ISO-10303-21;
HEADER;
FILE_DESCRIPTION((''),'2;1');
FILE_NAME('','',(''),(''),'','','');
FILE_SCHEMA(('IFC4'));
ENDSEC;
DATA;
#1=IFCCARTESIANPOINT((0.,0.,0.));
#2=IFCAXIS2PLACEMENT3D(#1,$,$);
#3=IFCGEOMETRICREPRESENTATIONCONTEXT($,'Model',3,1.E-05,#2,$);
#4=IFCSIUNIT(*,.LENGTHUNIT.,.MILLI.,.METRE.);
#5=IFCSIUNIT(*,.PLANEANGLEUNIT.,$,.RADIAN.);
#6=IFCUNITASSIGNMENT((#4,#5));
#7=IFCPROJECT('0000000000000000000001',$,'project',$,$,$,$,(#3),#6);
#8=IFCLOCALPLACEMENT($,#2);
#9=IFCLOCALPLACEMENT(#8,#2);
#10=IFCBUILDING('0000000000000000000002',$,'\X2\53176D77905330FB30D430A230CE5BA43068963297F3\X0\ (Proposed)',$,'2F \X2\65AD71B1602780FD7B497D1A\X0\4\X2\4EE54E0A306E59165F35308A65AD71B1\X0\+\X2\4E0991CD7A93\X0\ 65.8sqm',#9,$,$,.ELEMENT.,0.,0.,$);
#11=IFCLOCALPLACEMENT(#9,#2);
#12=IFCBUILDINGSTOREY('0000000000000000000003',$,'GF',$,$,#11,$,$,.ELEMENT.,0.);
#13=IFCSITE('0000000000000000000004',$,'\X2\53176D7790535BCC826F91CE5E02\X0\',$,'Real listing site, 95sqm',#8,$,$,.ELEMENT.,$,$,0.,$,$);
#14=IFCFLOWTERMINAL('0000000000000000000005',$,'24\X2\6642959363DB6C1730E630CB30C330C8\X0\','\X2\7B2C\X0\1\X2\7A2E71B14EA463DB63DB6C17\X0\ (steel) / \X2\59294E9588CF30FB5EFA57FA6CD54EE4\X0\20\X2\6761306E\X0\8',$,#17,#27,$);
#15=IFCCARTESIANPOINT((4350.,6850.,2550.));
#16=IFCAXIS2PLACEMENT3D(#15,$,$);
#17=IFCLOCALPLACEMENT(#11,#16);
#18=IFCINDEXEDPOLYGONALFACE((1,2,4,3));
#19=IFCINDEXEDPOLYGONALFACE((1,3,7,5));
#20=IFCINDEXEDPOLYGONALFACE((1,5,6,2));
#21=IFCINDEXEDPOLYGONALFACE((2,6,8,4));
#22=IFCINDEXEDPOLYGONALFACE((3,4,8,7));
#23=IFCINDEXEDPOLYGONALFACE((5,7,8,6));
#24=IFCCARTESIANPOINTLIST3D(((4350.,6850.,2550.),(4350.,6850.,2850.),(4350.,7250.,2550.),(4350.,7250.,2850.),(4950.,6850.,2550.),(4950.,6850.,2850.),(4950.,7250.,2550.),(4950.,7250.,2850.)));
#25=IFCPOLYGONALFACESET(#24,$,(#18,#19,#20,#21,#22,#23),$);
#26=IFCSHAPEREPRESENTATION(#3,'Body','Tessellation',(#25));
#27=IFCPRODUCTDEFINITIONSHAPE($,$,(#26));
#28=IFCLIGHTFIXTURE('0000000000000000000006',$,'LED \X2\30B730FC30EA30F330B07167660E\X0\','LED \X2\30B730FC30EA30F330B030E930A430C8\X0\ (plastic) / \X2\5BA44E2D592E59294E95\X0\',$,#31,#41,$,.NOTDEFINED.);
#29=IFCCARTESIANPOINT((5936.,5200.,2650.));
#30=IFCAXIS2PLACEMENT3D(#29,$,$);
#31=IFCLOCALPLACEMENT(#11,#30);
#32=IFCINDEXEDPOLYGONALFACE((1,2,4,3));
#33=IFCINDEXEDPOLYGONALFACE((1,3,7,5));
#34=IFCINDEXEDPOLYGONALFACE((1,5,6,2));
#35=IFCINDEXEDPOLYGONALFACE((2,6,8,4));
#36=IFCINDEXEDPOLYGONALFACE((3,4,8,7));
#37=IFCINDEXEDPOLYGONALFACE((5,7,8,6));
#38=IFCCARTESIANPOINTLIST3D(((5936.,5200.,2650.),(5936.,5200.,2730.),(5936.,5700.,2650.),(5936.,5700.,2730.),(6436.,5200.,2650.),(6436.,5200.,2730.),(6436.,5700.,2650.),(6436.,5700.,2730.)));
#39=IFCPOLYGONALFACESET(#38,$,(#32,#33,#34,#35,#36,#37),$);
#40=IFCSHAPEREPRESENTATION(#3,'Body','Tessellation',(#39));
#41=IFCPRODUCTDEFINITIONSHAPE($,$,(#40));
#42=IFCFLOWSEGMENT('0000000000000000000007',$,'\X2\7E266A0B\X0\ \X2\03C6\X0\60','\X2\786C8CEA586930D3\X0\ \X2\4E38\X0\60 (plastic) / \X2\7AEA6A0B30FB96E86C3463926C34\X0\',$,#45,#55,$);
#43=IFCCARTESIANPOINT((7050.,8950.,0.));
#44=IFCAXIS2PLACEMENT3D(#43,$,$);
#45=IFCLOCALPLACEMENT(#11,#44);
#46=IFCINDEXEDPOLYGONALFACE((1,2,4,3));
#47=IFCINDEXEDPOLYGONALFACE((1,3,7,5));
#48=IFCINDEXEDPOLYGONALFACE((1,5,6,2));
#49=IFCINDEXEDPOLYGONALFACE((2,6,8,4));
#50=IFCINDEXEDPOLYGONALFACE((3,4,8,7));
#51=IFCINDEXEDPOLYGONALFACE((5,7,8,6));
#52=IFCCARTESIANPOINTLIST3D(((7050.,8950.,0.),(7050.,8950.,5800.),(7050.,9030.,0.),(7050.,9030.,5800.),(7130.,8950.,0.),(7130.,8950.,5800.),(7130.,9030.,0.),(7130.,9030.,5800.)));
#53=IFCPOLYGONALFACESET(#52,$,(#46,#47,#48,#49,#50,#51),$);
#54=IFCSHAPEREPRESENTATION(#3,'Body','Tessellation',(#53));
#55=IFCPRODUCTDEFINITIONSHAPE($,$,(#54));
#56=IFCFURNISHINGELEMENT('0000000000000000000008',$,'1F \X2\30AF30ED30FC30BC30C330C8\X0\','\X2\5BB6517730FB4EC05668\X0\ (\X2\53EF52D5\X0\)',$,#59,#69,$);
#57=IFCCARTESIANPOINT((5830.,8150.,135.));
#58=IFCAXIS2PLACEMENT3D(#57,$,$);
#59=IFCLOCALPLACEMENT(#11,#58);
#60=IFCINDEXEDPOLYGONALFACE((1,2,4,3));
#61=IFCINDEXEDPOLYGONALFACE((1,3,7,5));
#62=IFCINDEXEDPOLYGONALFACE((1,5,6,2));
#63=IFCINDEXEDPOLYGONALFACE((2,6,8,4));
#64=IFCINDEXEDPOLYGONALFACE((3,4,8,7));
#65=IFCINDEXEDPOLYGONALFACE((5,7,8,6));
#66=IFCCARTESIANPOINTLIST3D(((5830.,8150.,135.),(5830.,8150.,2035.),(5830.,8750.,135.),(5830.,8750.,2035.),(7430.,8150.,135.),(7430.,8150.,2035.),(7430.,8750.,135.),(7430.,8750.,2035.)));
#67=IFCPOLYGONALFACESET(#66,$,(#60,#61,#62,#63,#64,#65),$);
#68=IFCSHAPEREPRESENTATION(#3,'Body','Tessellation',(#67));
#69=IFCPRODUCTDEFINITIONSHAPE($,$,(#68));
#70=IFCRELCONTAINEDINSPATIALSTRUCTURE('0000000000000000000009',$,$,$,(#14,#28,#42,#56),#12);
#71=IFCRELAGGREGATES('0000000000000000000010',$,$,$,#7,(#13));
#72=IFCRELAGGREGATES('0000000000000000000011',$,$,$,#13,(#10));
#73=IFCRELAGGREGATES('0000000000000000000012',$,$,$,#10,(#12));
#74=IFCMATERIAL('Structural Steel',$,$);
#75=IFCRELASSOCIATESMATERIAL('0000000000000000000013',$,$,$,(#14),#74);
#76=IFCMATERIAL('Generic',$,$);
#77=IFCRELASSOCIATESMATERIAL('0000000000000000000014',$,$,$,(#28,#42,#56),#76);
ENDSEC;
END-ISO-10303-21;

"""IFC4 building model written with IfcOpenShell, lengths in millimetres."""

from ifc_helpers import new_model, si_unit, frame, frame_2d, origin, place, context, project, spatial, rectangle, extrude, material, element, save


model = new_model("IFC4")

# Units and contexts
model_context = context("Model", 3, precision=1e-05, world=origin())
ifc_project = project(units=[si_unit("LENGTHUNIT", "METRE", prefix="MILLI"), si_unit("PLANEANGLEUNIT", "RADIAN")], contexts=[model_context])

# Site, building, storey
site_placement = place(None, origin())
site = spatial("IfcSite", under=ifc_project, at=site_placement, Name="北海道富良野市", ObjectType="Real listing site, 95sqm", CompositionType="ELEMENT", RefElevation=0.0)
building_placement = place(site_placement, origin())
building = spatial("IfcBuilding", under=site, at=building_placement, Name="北海道・ピアノ室と防音 (Proposed)", ObjectType="2F 断熱性能等級4以上の外張り断熱+三重窓 65.8sqm", CompositionType="ELEMENT", ElevationOfRefHeight=0.0, ElevationOfTerrain=0.0)
storey_placement = place(building_placement, origin())
storey = spatial("IfcBuildingStorey", under=building, at=storey_placement, Name="GF", CompositionType="ELEMENT", Elevation=0.0)

# Shared definitions
ifc_material_1 = material(Name="Generic")

# Flow terminal
ifc_material_2 = material(Name="Structural Steel")
flow_terminal_placement = place(storey_placement, frame((4350.0, 6850.0, 2550.0)))
element("IfcFlowTerminal", 1, at=flow_terminal_placement, inside=storey, material=ifc_material_2, Name="24時間換気ユニット", Description="第1種熱交換換気 (steel) / 天井裏・建基法令20条の8", context=model_context, shape_type="SweptSolid", body=[
    extrude(rectangle(XDim=600.0, YDim=400.0, at=frame_2d((300.0, 200.0))), frame((4350.0, 6850.0, 2550.0)), (0.0, 0.0, 1.0), 300.0),
])

# Light fixture
light_fixture_placement = place(storey_placement, frame((5936.0, 5200.0, 2650.0)))
element("IfcLightFixture", 2, at=light_fixture_placement, inside=storey, material=ifc_material_1, Name="LED シーリング照明", Description="LED シーリングライト (plastic) / 室中央天井", PredefinedType="NOTDEFINED", context=model_context, shape_type="SweptSolid", body=[
    extrude(rectangle(XDim=500.0, YDim=500.0, at=frame_2d((250.0, 250.0))), frame((5936.0, 5200.0, 2650.0)), (0.0, 0.0, 1.0), 80.0),
])

# Flow segment
flow_segment_placement = place(storey_placement, frame((7050.0, 8950.0, 0.0)))
element("IfcFlowSegment", 3, at=flow_segment_placement, inside=storey, material=ifc_material_1, Name="縦樋 φ60", Description="硬質塩ビ 丸60 (plastic) / 竪樋・雨水排水", context=model_context, shape_type="SweptSolid", body=[
    extrude(rectangle(XDim=80.0, YDim=80.0, at=frame_2d((40.0, 40.0))), frame((7050.0, 8950.0, 0.0)), (0.0, 0.0, 1.0), 5800.0),
])

# Furnishing element
furnishing_placement = place(storey_placement, frame((5830.0, 8150.0, 135.0)))
element("IfcFurnishingElement", 4, at=furnishing_placement, inside=storey, material=ifc_material_1, Name="1F クローゼット", Description="家具・什器 (可動)", context=model_context, shape_type="SweptSolid", body=[
    extrude(rectangle(XDim=1600.0, YDim=600.0, at=frame_2d((800.0, 300.0))), frame((5830.0, 8150.0, 135.0)), (0.0, 0.0, 1.0), 1900.0),
])

save(model, "model.ifc")
